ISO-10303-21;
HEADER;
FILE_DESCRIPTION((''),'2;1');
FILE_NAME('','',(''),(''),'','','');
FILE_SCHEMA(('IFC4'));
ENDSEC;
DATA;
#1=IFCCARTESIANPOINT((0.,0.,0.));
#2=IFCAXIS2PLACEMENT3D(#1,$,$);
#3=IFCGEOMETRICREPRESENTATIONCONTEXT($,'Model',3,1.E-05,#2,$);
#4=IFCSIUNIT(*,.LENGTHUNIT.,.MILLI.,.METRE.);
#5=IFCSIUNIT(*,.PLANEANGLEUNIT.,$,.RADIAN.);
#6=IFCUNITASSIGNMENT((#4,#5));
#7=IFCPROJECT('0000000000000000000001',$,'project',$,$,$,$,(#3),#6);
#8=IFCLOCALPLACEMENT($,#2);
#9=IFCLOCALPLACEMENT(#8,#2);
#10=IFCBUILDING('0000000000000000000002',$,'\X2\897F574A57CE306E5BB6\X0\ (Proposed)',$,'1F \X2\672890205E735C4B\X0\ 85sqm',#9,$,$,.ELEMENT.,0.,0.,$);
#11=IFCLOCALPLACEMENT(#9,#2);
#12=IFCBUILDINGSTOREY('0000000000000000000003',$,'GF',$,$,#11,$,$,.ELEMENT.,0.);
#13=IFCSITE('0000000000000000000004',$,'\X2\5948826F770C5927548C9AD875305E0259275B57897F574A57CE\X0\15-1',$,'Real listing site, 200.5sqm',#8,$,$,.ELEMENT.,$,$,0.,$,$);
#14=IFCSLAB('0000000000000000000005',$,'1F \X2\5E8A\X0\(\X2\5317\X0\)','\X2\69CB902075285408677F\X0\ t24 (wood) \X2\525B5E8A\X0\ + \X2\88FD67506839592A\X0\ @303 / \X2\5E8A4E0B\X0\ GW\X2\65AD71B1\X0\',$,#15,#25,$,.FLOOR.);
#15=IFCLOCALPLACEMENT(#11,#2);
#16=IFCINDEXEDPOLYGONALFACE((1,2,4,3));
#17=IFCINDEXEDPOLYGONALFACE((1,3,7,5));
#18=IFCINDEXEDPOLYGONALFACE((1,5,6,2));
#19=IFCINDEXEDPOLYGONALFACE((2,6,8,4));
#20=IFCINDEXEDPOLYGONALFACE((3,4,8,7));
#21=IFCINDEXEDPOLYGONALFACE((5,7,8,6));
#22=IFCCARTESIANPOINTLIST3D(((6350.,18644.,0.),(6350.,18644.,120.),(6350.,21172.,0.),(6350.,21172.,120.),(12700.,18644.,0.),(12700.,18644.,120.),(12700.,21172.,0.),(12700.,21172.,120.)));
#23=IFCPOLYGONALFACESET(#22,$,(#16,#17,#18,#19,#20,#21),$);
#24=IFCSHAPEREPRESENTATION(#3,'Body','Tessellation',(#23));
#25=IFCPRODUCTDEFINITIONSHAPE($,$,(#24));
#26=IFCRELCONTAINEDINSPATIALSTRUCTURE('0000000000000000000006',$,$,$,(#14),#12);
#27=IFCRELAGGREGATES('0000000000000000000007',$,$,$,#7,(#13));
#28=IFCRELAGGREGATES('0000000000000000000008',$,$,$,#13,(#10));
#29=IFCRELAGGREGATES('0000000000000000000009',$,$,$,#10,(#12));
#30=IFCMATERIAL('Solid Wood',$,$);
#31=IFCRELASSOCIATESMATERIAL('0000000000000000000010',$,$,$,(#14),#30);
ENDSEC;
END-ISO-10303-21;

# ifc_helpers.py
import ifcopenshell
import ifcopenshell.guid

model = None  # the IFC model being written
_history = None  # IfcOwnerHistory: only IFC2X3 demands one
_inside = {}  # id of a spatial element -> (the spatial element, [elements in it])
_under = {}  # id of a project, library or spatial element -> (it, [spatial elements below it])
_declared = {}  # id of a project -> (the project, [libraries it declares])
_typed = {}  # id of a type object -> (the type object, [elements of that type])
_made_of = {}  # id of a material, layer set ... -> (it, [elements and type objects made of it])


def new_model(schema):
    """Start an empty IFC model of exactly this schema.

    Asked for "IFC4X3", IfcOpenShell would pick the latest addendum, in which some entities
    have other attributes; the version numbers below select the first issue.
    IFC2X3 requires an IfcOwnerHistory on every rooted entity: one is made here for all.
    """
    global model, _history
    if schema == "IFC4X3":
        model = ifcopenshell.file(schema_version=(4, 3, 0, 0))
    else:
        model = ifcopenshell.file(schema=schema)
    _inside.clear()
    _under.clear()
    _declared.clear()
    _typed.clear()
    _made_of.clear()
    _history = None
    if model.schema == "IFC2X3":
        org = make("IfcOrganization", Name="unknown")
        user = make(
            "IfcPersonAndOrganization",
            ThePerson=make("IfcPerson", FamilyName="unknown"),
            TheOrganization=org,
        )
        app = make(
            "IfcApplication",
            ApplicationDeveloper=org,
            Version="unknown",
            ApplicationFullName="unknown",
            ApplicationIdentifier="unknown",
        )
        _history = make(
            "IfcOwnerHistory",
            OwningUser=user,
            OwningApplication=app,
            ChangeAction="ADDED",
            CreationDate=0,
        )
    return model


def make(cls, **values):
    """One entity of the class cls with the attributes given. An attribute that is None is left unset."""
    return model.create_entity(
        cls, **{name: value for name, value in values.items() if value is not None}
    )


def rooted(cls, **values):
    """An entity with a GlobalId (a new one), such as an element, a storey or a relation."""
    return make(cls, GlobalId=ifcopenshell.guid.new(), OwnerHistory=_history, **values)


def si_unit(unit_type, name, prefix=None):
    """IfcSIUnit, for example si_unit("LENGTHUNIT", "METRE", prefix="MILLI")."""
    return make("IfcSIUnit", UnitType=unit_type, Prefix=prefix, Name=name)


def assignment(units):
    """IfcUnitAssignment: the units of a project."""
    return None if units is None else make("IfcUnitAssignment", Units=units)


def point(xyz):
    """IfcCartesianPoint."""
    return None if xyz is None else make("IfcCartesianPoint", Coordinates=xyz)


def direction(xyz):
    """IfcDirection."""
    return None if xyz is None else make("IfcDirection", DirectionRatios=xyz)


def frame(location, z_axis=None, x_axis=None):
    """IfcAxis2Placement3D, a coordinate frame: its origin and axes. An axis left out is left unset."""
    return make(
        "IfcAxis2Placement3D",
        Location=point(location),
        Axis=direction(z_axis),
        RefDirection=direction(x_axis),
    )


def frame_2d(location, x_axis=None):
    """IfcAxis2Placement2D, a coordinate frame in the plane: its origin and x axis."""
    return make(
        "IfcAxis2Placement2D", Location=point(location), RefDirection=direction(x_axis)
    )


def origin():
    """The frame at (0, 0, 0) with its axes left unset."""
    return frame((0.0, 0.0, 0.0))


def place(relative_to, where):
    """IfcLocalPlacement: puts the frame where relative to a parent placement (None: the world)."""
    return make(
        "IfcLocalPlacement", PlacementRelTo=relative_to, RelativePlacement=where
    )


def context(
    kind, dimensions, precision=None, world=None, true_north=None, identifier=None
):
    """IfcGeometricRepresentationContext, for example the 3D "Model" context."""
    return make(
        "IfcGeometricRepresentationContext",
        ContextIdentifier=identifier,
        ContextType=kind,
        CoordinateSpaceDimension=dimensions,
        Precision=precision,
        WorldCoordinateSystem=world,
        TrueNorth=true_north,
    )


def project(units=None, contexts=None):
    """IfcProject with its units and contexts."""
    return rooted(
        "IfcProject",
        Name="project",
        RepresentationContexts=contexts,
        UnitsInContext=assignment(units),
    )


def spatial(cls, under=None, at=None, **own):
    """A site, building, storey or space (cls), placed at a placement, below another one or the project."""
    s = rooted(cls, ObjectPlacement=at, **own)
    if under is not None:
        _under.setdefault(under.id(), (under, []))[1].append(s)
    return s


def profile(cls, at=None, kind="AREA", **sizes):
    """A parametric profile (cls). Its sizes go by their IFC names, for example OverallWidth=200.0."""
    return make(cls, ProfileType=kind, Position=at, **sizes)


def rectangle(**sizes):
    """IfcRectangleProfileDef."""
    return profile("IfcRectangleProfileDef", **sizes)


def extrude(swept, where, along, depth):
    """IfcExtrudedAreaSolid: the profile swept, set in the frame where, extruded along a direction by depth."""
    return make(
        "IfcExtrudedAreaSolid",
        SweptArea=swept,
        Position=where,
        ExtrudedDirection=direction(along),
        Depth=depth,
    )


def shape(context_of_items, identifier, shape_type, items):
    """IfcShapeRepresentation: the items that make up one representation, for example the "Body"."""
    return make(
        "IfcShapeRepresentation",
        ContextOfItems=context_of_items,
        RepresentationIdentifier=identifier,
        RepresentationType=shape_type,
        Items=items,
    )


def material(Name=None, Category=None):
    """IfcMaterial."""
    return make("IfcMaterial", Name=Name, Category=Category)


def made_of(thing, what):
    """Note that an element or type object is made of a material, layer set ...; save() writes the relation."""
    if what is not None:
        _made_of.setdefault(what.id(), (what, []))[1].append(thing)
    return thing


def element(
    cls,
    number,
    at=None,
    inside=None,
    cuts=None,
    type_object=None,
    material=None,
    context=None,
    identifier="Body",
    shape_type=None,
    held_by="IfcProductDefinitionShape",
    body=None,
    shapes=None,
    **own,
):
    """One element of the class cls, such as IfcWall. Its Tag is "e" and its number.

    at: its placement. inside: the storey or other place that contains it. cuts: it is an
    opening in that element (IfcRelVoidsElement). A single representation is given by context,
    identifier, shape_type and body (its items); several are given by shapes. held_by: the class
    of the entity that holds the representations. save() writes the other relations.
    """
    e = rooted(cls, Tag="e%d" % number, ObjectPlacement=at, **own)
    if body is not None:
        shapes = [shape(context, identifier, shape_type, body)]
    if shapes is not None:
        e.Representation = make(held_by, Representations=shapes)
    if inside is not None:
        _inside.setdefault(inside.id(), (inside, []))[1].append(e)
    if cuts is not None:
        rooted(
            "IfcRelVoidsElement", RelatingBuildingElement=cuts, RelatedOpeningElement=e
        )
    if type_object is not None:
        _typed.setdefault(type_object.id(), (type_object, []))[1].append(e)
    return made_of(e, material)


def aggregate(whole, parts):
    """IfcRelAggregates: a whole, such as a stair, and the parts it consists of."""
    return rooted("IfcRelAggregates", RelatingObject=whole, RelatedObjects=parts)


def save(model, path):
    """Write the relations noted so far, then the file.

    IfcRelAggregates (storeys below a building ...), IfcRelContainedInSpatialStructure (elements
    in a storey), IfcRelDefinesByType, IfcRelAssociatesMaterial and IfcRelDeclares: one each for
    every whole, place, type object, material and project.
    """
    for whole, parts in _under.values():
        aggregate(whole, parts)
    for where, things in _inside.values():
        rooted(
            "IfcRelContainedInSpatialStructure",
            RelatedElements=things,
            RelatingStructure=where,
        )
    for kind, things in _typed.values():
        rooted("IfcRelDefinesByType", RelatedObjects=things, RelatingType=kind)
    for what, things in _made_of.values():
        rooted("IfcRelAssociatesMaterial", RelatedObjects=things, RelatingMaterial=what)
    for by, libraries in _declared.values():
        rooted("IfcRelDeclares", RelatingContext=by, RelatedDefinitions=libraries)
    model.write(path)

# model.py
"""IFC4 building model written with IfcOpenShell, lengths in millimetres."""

from ifc_helpers import new_model, si_unit, frame, frame_2d, origin, place, context, project, spatial, rectangle, extrude, material, element, save


model = new_model("IFC4")

# Units and contexts
model_context = context("Model", 3, precision=1e-05, world=origin())
ifc_project = project(units=[si_unit("LENGTHUNIT", "METRE", prefix="MILLI"), si_unit("PLANEANGLEUNIT", "RADIAN")], contexts=[model_context])

# Site, building, storey
site_placement = place(None, origin())
site = spatial("IfcSite", under=ifc_project, at=site_placement, Name="奈良県大和高田市大字西坊城15-1", ObjectType="Real listing site, 200.5sqm", CompositionType="ELEMENT", RefElevation=0.0)
building_placement = place(site_placement, origin())
building = spatial("IfcBuilding", under=site, at=building_placement, Name="西坊城の家 (Proposed)", ObjectType="1F 木造平屋 85sqm", CompositionType="ELEMENT", ElevationOfRefHeight=0.0, ElevationOfTerrain=0.0)
storey_placement = place(building_placement, origin())
storey = spatial("IfcBuildingStorey", under=building, at=storey_placement, Name="GF", CompositionType="ELEMENT", Elevation=0.0)

# Slab
ifc_material_1 = material(Name="Solid Wood")
slab_1_placement = place(storey_placement, frame((3175.0, 9322.0, 0.0)))
element("IfcSlab", 1, at=slab_1_placement, inside=storey, material=ifc_material_1, Name="1F 床(北)", Description="構造用合板 t24 (wood) 剛床 + 製材根太 @303 / 床下 GW断熱", PredefinedType="FLOOR", context=model_context, shape_type="SweptSolid", body=[
    extrude(rectangle(XDim=6350.0, YDim=2528.0, at=frame_2d((3175.0, 1264.0))), frame((3175.0, 9322.0, 0.0)), (0.0, 0.0, 1.0), 120.0),
])

save(model, "model.ifc")
